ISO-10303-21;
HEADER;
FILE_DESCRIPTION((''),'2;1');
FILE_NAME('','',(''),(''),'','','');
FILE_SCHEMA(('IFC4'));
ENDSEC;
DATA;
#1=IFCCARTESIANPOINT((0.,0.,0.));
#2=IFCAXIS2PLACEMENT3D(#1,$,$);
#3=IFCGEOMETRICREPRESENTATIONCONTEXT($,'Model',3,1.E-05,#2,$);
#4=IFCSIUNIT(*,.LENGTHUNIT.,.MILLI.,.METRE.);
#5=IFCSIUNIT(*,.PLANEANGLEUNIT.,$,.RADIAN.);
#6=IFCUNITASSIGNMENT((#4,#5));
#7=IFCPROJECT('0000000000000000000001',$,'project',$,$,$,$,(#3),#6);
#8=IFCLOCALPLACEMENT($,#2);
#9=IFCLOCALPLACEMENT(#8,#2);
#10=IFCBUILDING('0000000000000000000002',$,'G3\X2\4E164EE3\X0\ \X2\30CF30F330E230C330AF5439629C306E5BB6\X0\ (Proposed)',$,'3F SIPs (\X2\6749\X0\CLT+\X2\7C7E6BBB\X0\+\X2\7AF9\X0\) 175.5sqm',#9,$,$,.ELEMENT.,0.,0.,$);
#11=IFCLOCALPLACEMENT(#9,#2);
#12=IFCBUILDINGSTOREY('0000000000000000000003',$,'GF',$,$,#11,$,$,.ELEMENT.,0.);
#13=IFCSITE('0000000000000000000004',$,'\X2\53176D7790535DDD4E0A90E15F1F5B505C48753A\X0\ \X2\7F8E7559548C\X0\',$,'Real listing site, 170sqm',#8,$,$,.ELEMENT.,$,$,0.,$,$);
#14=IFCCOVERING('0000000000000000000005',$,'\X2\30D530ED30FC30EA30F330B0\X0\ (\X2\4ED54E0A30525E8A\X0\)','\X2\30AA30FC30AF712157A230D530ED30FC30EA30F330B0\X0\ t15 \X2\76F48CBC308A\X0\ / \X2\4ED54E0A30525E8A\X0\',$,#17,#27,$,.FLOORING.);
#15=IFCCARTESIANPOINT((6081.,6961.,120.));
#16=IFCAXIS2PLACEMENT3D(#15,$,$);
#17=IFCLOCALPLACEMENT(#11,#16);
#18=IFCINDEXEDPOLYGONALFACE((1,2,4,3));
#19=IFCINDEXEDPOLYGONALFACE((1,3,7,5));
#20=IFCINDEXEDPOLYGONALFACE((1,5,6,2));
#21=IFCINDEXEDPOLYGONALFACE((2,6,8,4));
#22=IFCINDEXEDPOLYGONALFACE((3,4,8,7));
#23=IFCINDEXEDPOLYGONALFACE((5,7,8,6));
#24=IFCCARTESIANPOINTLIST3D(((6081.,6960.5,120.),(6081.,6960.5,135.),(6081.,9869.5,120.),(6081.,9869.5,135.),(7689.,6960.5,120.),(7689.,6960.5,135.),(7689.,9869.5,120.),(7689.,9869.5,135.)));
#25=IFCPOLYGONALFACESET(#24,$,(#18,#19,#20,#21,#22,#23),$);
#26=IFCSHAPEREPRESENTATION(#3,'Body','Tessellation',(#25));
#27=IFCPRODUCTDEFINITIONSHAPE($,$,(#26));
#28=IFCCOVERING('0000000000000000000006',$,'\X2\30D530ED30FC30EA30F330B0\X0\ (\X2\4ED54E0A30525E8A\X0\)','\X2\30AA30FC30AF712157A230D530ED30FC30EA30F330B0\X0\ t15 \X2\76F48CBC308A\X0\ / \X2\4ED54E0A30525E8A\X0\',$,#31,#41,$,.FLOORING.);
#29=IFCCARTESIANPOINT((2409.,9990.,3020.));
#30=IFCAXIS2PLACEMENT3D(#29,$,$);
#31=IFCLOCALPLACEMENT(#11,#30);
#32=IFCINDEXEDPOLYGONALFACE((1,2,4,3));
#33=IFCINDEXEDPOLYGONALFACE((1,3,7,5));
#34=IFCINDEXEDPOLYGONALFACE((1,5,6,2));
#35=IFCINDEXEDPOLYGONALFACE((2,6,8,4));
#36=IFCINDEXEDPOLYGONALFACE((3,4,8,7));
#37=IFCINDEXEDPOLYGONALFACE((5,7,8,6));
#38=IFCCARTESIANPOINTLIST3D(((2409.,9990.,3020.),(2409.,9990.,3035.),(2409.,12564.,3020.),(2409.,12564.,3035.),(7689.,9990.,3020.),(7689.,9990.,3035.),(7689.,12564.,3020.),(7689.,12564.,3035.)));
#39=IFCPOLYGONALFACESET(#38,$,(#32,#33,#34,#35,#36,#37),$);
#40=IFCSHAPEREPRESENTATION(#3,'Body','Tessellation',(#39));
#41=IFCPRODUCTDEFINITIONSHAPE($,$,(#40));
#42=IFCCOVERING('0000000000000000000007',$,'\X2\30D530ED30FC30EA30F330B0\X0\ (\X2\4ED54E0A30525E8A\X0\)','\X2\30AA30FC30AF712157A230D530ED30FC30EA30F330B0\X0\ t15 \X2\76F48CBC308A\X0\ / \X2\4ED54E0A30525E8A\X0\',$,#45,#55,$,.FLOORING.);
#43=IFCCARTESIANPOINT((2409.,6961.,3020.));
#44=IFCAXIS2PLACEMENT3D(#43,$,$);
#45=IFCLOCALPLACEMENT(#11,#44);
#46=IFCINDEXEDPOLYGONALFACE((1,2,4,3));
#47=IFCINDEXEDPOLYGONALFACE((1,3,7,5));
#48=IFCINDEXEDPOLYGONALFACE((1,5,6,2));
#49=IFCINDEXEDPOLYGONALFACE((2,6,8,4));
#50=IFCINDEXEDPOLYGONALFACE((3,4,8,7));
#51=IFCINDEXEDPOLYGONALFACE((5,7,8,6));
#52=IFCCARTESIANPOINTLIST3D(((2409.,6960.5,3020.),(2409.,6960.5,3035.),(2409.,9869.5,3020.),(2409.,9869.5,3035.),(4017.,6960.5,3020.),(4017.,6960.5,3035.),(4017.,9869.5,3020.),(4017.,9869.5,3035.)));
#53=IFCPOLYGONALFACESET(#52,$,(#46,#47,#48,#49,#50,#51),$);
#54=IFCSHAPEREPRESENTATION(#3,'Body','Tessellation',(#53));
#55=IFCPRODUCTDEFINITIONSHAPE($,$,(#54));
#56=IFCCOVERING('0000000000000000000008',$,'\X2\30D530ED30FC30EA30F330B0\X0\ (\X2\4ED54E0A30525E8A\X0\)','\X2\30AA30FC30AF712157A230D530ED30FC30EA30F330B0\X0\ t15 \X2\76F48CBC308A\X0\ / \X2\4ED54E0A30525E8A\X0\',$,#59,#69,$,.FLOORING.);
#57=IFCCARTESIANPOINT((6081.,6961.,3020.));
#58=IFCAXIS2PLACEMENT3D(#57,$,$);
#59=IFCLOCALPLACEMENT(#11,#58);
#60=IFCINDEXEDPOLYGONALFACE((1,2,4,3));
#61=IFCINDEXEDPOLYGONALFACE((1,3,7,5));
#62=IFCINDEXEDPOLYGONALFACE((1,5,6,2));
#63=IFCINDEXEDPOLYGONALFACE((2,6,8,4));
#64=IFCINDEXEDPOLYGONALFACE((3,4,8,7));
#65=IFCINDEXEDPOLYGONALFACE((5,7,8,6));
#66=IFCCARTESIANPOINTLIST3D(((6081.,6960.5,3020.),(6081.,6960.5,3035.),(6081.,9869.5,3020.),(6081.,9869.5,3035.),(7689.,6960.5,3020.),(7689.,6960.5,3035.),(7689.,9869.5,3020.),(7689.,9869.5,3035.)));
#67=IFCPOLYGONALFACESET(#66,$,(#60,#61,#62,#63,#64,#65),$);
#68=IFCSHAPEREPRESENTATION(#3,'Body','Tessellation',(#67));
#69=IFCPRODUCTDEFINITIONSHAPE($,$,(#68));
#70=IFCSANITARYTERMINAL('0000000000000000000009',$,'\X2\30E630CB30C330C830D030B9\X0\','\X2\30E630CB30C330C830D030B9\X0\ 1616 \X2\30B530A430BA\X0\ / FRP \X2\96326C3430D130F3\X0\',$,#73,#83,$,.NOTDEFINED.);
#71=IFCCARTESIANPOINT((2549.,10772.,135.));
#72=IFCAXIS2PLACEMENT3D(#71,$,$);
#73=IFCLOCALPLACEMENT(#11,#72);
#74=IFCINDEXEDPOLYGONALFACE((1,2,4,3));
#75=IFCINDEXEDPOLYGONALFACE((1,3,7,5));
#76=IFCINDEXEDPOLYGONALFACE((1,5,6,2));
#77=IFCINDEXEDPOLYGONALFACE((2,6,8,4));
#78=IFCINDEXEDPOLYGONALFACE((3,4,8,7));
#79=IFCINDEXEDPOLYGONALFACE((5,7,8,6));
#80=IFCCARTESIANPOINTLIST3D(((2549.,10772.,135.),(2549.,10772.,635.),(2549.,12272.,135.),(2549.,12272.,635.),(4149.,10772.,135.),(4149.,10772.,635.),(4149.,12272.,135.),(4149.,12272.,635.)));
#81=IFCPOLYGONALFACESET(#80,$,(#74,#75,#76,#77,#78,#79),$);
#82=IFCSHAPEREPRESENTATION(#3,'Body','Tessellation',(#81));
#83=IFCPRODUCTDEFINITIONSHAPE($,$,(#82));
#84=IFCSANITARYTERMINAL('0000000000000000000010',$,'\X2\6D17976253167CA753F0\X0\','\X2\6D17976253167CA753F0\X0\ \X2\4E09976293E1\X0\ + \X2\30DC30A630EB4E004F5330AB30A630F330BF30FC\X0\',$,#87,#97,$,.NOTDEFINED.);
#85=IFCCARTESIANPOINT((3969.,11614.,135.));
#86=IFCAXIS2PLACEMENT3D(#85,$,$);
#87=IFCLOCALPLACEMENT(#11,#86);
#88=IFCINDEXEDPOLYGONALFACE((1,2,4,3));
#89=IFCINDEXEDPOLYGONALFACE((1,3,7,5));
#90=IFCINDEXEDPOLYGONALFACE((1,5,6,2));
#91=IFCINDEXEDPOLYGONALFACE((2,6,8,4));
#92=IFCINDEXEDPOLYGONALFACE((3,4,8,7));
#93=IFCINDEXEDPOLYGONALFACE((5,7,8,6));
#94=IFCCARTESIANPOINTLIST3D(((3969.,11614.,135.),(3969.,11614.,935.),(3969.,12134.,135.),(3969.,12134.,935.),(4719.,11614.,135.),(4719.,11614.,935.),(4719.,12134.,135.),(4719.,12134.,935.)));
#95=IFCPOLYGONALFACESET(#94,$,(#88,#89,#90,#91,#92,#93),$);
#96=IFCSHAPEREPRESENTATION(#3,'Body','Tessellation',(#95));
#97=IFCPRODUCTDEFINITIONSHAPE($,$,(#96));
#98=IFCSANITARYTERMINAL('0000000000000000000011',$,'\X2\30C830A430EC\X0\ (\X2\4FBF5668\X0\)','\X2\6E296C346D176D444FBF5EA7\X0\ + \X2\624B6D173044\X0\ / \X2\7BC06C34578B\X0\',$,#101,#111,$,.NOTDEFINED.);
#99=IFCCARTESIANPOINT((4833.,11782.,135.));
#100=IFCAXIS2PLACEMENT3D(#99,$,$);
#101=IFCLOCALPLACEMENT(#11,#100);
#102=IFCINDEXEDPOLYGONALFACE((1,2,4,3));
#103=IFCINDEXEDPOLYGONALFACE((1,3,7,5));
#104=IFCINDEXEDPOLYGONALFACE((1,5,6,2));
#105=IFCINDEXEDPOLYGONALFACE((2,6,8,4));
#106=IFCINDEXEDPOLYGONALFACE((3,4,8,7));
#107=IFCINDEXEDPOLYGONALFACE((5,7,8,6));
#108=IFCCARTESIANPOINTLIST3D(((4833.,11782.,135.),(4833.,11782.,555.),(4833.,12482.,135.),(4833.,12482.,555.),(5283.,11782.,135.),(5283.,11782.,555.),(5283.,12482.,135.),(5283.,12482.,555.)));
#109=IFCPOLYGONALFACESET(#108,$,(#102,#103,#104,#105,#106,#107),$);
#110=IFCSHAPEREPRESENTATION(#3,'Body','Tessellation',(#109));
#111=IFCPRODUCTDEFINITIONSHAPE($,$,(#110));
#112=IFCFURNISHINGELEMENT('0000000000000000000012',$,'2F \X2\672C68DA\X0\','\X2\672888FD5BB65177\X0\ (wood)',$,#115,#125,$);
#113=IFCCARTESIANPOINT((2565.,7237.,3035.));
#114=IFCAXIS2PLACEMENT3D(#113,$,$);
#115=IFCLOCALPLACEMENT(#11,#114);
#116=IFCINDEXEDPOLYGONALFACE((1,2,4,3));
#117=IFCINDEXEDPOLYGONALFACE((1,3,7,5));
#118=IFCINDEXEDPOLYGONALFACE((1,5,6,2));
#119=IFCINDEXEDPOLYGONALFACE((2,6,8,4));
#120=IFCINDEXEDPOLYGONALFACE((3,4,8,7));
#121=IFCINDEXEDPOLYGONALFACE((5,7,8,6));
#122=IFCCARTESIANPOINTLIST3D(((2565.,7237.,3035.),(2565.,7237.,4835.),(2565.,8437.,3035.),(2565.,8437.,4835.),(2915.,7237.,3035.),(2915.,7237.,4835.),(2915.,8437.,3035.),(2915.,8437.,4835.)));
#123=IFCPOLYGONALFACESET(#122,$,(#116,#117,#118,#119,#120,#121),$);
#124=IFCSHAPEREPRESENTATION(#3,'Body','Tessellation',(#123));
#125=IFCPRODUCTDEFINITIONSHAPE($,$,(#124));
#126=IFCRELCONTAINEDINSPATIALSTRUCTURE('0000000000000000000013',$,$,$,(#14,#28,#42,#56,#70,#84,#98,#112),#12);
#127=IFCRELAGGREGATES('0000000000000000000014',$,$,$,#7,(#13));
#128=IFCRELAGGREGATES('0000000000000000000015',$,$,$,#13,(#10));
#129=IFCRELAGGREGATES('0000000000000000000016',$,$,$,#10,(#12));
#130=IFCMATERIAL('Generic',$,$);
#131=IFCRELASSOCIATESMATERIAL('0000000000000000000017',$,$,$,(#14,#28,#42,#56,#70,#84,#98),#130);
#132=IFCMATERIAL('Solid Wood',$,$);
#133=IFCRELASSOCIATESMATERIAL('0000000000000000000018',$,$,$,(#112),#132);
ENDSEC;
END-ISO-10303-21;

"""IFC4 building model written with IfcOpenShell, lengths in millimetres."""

from ifc_helpers import new_model, si_unit, frame, frame_2d, origin, place, context, project, spatial, rectangle, extrude, material, element, save


model = new_model("IFC4")

# Units and contexts
model_context = context("Model", 3, precision=1e-05, world=origin())
ifc_project = project(units=[si_unit("LENGTHUNIT", "METRE", prefix="MILLI"), si_unit("PLANEANGLEUNIT", "RADIAN")], contexts=[model_context])

# Site, building, storey
site_placement = place(None, origin())
site = spatial("IfcSite", under=ifc_project, at=site_placement, Name="北海道川上郡弟子屈町 美留和", ObjectType="Real listing site, 170sqm", CompositionType="ELEMENT", RefElevation=0.0)
building_placement = place(site_placement, origin())
building = spatial("IfcBuilding", under=site, at=building_placement, Name="G3世代 ハンモック吹抜の家 (Proposed)", ObjectType="3F SIPs (杉CLT+籾殻+竹) 175.5sqm", CompositionType="ELEMENT", ElevationOfRefHeight=0.0, ElevationOfTerrain=0.0)
storey_placement = place(building_placement, origin())
storey = spatial("IfcBuildingStorey", under=building, at=storey_placement, Name="GF", CompositionType="ELEMENT", Elevation=0.0)

# Shared definitions
ifc_material_1 = material(Name="Solid Wood")

# Coverings
ifc_material_2 = material(Name="Generic")
covering_1_placement = place(storey_placement, frame((6081.0, 6961.0, 120.0)))
element("IfcCovering", 1, at=covering_1_placement, inside=storey, material=ifc_material_2, Name="フローリング (仕上げ床)", Description="オーク無垢フローリング t15 直貼り / 仕上げ床", PredefinedType="FLOORING", context=model_context, shape_type="SweptSolid", body=[
    extrude(rectangle(XDim=1608.0, YDim=2909.0, at=frame_2d((804.0, 1454.0))), frame((6081.0, 6961.0, 120.0)), (0.0, 0.0, 1.0), 15.0),
])
covering_2_placement = place(storey_placement, frame((2409.0, 9990.0, 3020.0)))
element("IfcCovering", 2, at=covering_2_placement, inside=storey, material=ifc_material_2, Name="フローリング (仕上げ床)", Description="オーク無垢フローリング t15 直貼り / 仕上げ床", PredefinedType="FLOORING", context=model_context, shape_type="SweptSolid", body=[
    extrude(rectangle(XDim=5280.0, YDim=2574.0, at=frame_2d((2640.0, 1287.0))), frame((2409.0, 9990.0, 3020.0)), (0.0, 0.0, 1.0), 15.0),
])
covering_3_placement = place(storey_placement, frame((2409.0, 6961.0, 3020.0)))
element("IfcCovering", 3, at=covering_3_placement, inside=storey, material=ifc_material_2, Name="フローリング (仕上げ床)", Description="オーク無垢フローリング t15 直貼り / 仕上げ床", PredefinedType="FLOORING", context=model_context, shape_type="SweptSolid", body=[
    extrude(rectangle(XDim=1608.0, YDim=2909.0, at=frame_2d((804.0, 1454.0))), frame((2409.0, 6961.0, 3020.0)), (0.0, 0.0, 1.0), 15.0),
])
covering_4_placement = place(storey_placement, frame((6081.0, 6961.0, 3020.0)))
element("IfcCovering", 4, at=covering_4_placement, inside=storey, material=ifc_material_2, Name="フローリング (仕上げ床)", Description="オーク無垢フローリング t15 直貼り / 仕上げ床", PredefinedType="FLOORING", context=model_context, shape_type="SweptSolid", body=[
    extrude(rectangle(XDim=1608.0, YDim=2909.0, at=frame_2d((804.0, 1454.0))), frame((6081.0, 6961.0, 3020.0)), (0.0, 0.0, 1.0), 15.0),
])

# Sanitary terminals
sanitary_terminal_1_placement = place(storey_placement, frame((2549.0, 10772.0, 135.0)))
element("IfcSanitaryTerminal", 5, at=sanitary_terminal_1_placement, inside=storey, material=ifc_material_2, Name="ユニットバス", Description="ユニットバス 1616 サイズ / FRP 防水パン", PredefinedType="NOTDEFINED", context=model_context, shape_type="SweptSolid", body=[
    extrude(rectangle(XDim=1600.0, YDim=1500.0, at=frame_2d((800.0, 750.0))), frame((2549.0, 10772.0, 135.0)), (0.0, 0.0, 1.0), 500.0),
])
sanitary_terminal_2_placement = place(storey_placement, frame((3969.0, 11614.0, 135.0)))
element("IfcSanitaryTerminal", 6, at=sanitary_terminal_2_placement, inside=storey, material=ifc_material_2, Name="洗面化粧台", Description="洗面化粧台 三面鏡 + ボウル一体カウンター", PredefinedType="NOTDEFINED", context=model_context, shape_type="SweptSolid", body=[
    extrude(rectangle(XDim=750.0, YDim=520.0, at=frame_2d((375.0, 260.0))), frame((3969.0, 11614.0, 135.0)), (0.0, 0.0, 1.0), 800.0),
])
sanitary_terminal_3_placement = place(storey_placement, frame((4833.0, 11782.0, 135.0)))
element("IfcSanitaryTerminal", 7, at=sanitary_terminal_3_placement, inside=storey, material=ifc_material_2, Name="トイレ (便器)", Description="温水洗浄便座 + 手洗い / 節水型", PredefinedType="NOTDEFINED", context=model_context, shape_type="SweptSolid", body=[
    extrude(rectangle(XDim=450.0, YDim=700.0, at=frame_2d((225.0, 350.0))), frame((4833.0, 11782.0, 135.0)), (0.0, 0.0, 1.0), 420.0),
])

# Furnishing element
furnishing_placement = place(storey_placement, frame((2565.0, 7237.0, 3035.0)))
element("IfcFurnishingElement", 8, at=furnishing_placement, inside=storey, material=ifc_material_1, Name="2F 本棚", Description="木製家具 (wood)", context=model_context, shape_type="SweptSolid", body=[
    extrude(rectangle(XDim=350.0, YDim=1200.0, at=frame_2d((175.0, 600.0))), frame((2565.0, 7237.0, 3035.0)), (0.0, 0.0, 1.0), 1800.0),
])

save(model, "model.ifc")
